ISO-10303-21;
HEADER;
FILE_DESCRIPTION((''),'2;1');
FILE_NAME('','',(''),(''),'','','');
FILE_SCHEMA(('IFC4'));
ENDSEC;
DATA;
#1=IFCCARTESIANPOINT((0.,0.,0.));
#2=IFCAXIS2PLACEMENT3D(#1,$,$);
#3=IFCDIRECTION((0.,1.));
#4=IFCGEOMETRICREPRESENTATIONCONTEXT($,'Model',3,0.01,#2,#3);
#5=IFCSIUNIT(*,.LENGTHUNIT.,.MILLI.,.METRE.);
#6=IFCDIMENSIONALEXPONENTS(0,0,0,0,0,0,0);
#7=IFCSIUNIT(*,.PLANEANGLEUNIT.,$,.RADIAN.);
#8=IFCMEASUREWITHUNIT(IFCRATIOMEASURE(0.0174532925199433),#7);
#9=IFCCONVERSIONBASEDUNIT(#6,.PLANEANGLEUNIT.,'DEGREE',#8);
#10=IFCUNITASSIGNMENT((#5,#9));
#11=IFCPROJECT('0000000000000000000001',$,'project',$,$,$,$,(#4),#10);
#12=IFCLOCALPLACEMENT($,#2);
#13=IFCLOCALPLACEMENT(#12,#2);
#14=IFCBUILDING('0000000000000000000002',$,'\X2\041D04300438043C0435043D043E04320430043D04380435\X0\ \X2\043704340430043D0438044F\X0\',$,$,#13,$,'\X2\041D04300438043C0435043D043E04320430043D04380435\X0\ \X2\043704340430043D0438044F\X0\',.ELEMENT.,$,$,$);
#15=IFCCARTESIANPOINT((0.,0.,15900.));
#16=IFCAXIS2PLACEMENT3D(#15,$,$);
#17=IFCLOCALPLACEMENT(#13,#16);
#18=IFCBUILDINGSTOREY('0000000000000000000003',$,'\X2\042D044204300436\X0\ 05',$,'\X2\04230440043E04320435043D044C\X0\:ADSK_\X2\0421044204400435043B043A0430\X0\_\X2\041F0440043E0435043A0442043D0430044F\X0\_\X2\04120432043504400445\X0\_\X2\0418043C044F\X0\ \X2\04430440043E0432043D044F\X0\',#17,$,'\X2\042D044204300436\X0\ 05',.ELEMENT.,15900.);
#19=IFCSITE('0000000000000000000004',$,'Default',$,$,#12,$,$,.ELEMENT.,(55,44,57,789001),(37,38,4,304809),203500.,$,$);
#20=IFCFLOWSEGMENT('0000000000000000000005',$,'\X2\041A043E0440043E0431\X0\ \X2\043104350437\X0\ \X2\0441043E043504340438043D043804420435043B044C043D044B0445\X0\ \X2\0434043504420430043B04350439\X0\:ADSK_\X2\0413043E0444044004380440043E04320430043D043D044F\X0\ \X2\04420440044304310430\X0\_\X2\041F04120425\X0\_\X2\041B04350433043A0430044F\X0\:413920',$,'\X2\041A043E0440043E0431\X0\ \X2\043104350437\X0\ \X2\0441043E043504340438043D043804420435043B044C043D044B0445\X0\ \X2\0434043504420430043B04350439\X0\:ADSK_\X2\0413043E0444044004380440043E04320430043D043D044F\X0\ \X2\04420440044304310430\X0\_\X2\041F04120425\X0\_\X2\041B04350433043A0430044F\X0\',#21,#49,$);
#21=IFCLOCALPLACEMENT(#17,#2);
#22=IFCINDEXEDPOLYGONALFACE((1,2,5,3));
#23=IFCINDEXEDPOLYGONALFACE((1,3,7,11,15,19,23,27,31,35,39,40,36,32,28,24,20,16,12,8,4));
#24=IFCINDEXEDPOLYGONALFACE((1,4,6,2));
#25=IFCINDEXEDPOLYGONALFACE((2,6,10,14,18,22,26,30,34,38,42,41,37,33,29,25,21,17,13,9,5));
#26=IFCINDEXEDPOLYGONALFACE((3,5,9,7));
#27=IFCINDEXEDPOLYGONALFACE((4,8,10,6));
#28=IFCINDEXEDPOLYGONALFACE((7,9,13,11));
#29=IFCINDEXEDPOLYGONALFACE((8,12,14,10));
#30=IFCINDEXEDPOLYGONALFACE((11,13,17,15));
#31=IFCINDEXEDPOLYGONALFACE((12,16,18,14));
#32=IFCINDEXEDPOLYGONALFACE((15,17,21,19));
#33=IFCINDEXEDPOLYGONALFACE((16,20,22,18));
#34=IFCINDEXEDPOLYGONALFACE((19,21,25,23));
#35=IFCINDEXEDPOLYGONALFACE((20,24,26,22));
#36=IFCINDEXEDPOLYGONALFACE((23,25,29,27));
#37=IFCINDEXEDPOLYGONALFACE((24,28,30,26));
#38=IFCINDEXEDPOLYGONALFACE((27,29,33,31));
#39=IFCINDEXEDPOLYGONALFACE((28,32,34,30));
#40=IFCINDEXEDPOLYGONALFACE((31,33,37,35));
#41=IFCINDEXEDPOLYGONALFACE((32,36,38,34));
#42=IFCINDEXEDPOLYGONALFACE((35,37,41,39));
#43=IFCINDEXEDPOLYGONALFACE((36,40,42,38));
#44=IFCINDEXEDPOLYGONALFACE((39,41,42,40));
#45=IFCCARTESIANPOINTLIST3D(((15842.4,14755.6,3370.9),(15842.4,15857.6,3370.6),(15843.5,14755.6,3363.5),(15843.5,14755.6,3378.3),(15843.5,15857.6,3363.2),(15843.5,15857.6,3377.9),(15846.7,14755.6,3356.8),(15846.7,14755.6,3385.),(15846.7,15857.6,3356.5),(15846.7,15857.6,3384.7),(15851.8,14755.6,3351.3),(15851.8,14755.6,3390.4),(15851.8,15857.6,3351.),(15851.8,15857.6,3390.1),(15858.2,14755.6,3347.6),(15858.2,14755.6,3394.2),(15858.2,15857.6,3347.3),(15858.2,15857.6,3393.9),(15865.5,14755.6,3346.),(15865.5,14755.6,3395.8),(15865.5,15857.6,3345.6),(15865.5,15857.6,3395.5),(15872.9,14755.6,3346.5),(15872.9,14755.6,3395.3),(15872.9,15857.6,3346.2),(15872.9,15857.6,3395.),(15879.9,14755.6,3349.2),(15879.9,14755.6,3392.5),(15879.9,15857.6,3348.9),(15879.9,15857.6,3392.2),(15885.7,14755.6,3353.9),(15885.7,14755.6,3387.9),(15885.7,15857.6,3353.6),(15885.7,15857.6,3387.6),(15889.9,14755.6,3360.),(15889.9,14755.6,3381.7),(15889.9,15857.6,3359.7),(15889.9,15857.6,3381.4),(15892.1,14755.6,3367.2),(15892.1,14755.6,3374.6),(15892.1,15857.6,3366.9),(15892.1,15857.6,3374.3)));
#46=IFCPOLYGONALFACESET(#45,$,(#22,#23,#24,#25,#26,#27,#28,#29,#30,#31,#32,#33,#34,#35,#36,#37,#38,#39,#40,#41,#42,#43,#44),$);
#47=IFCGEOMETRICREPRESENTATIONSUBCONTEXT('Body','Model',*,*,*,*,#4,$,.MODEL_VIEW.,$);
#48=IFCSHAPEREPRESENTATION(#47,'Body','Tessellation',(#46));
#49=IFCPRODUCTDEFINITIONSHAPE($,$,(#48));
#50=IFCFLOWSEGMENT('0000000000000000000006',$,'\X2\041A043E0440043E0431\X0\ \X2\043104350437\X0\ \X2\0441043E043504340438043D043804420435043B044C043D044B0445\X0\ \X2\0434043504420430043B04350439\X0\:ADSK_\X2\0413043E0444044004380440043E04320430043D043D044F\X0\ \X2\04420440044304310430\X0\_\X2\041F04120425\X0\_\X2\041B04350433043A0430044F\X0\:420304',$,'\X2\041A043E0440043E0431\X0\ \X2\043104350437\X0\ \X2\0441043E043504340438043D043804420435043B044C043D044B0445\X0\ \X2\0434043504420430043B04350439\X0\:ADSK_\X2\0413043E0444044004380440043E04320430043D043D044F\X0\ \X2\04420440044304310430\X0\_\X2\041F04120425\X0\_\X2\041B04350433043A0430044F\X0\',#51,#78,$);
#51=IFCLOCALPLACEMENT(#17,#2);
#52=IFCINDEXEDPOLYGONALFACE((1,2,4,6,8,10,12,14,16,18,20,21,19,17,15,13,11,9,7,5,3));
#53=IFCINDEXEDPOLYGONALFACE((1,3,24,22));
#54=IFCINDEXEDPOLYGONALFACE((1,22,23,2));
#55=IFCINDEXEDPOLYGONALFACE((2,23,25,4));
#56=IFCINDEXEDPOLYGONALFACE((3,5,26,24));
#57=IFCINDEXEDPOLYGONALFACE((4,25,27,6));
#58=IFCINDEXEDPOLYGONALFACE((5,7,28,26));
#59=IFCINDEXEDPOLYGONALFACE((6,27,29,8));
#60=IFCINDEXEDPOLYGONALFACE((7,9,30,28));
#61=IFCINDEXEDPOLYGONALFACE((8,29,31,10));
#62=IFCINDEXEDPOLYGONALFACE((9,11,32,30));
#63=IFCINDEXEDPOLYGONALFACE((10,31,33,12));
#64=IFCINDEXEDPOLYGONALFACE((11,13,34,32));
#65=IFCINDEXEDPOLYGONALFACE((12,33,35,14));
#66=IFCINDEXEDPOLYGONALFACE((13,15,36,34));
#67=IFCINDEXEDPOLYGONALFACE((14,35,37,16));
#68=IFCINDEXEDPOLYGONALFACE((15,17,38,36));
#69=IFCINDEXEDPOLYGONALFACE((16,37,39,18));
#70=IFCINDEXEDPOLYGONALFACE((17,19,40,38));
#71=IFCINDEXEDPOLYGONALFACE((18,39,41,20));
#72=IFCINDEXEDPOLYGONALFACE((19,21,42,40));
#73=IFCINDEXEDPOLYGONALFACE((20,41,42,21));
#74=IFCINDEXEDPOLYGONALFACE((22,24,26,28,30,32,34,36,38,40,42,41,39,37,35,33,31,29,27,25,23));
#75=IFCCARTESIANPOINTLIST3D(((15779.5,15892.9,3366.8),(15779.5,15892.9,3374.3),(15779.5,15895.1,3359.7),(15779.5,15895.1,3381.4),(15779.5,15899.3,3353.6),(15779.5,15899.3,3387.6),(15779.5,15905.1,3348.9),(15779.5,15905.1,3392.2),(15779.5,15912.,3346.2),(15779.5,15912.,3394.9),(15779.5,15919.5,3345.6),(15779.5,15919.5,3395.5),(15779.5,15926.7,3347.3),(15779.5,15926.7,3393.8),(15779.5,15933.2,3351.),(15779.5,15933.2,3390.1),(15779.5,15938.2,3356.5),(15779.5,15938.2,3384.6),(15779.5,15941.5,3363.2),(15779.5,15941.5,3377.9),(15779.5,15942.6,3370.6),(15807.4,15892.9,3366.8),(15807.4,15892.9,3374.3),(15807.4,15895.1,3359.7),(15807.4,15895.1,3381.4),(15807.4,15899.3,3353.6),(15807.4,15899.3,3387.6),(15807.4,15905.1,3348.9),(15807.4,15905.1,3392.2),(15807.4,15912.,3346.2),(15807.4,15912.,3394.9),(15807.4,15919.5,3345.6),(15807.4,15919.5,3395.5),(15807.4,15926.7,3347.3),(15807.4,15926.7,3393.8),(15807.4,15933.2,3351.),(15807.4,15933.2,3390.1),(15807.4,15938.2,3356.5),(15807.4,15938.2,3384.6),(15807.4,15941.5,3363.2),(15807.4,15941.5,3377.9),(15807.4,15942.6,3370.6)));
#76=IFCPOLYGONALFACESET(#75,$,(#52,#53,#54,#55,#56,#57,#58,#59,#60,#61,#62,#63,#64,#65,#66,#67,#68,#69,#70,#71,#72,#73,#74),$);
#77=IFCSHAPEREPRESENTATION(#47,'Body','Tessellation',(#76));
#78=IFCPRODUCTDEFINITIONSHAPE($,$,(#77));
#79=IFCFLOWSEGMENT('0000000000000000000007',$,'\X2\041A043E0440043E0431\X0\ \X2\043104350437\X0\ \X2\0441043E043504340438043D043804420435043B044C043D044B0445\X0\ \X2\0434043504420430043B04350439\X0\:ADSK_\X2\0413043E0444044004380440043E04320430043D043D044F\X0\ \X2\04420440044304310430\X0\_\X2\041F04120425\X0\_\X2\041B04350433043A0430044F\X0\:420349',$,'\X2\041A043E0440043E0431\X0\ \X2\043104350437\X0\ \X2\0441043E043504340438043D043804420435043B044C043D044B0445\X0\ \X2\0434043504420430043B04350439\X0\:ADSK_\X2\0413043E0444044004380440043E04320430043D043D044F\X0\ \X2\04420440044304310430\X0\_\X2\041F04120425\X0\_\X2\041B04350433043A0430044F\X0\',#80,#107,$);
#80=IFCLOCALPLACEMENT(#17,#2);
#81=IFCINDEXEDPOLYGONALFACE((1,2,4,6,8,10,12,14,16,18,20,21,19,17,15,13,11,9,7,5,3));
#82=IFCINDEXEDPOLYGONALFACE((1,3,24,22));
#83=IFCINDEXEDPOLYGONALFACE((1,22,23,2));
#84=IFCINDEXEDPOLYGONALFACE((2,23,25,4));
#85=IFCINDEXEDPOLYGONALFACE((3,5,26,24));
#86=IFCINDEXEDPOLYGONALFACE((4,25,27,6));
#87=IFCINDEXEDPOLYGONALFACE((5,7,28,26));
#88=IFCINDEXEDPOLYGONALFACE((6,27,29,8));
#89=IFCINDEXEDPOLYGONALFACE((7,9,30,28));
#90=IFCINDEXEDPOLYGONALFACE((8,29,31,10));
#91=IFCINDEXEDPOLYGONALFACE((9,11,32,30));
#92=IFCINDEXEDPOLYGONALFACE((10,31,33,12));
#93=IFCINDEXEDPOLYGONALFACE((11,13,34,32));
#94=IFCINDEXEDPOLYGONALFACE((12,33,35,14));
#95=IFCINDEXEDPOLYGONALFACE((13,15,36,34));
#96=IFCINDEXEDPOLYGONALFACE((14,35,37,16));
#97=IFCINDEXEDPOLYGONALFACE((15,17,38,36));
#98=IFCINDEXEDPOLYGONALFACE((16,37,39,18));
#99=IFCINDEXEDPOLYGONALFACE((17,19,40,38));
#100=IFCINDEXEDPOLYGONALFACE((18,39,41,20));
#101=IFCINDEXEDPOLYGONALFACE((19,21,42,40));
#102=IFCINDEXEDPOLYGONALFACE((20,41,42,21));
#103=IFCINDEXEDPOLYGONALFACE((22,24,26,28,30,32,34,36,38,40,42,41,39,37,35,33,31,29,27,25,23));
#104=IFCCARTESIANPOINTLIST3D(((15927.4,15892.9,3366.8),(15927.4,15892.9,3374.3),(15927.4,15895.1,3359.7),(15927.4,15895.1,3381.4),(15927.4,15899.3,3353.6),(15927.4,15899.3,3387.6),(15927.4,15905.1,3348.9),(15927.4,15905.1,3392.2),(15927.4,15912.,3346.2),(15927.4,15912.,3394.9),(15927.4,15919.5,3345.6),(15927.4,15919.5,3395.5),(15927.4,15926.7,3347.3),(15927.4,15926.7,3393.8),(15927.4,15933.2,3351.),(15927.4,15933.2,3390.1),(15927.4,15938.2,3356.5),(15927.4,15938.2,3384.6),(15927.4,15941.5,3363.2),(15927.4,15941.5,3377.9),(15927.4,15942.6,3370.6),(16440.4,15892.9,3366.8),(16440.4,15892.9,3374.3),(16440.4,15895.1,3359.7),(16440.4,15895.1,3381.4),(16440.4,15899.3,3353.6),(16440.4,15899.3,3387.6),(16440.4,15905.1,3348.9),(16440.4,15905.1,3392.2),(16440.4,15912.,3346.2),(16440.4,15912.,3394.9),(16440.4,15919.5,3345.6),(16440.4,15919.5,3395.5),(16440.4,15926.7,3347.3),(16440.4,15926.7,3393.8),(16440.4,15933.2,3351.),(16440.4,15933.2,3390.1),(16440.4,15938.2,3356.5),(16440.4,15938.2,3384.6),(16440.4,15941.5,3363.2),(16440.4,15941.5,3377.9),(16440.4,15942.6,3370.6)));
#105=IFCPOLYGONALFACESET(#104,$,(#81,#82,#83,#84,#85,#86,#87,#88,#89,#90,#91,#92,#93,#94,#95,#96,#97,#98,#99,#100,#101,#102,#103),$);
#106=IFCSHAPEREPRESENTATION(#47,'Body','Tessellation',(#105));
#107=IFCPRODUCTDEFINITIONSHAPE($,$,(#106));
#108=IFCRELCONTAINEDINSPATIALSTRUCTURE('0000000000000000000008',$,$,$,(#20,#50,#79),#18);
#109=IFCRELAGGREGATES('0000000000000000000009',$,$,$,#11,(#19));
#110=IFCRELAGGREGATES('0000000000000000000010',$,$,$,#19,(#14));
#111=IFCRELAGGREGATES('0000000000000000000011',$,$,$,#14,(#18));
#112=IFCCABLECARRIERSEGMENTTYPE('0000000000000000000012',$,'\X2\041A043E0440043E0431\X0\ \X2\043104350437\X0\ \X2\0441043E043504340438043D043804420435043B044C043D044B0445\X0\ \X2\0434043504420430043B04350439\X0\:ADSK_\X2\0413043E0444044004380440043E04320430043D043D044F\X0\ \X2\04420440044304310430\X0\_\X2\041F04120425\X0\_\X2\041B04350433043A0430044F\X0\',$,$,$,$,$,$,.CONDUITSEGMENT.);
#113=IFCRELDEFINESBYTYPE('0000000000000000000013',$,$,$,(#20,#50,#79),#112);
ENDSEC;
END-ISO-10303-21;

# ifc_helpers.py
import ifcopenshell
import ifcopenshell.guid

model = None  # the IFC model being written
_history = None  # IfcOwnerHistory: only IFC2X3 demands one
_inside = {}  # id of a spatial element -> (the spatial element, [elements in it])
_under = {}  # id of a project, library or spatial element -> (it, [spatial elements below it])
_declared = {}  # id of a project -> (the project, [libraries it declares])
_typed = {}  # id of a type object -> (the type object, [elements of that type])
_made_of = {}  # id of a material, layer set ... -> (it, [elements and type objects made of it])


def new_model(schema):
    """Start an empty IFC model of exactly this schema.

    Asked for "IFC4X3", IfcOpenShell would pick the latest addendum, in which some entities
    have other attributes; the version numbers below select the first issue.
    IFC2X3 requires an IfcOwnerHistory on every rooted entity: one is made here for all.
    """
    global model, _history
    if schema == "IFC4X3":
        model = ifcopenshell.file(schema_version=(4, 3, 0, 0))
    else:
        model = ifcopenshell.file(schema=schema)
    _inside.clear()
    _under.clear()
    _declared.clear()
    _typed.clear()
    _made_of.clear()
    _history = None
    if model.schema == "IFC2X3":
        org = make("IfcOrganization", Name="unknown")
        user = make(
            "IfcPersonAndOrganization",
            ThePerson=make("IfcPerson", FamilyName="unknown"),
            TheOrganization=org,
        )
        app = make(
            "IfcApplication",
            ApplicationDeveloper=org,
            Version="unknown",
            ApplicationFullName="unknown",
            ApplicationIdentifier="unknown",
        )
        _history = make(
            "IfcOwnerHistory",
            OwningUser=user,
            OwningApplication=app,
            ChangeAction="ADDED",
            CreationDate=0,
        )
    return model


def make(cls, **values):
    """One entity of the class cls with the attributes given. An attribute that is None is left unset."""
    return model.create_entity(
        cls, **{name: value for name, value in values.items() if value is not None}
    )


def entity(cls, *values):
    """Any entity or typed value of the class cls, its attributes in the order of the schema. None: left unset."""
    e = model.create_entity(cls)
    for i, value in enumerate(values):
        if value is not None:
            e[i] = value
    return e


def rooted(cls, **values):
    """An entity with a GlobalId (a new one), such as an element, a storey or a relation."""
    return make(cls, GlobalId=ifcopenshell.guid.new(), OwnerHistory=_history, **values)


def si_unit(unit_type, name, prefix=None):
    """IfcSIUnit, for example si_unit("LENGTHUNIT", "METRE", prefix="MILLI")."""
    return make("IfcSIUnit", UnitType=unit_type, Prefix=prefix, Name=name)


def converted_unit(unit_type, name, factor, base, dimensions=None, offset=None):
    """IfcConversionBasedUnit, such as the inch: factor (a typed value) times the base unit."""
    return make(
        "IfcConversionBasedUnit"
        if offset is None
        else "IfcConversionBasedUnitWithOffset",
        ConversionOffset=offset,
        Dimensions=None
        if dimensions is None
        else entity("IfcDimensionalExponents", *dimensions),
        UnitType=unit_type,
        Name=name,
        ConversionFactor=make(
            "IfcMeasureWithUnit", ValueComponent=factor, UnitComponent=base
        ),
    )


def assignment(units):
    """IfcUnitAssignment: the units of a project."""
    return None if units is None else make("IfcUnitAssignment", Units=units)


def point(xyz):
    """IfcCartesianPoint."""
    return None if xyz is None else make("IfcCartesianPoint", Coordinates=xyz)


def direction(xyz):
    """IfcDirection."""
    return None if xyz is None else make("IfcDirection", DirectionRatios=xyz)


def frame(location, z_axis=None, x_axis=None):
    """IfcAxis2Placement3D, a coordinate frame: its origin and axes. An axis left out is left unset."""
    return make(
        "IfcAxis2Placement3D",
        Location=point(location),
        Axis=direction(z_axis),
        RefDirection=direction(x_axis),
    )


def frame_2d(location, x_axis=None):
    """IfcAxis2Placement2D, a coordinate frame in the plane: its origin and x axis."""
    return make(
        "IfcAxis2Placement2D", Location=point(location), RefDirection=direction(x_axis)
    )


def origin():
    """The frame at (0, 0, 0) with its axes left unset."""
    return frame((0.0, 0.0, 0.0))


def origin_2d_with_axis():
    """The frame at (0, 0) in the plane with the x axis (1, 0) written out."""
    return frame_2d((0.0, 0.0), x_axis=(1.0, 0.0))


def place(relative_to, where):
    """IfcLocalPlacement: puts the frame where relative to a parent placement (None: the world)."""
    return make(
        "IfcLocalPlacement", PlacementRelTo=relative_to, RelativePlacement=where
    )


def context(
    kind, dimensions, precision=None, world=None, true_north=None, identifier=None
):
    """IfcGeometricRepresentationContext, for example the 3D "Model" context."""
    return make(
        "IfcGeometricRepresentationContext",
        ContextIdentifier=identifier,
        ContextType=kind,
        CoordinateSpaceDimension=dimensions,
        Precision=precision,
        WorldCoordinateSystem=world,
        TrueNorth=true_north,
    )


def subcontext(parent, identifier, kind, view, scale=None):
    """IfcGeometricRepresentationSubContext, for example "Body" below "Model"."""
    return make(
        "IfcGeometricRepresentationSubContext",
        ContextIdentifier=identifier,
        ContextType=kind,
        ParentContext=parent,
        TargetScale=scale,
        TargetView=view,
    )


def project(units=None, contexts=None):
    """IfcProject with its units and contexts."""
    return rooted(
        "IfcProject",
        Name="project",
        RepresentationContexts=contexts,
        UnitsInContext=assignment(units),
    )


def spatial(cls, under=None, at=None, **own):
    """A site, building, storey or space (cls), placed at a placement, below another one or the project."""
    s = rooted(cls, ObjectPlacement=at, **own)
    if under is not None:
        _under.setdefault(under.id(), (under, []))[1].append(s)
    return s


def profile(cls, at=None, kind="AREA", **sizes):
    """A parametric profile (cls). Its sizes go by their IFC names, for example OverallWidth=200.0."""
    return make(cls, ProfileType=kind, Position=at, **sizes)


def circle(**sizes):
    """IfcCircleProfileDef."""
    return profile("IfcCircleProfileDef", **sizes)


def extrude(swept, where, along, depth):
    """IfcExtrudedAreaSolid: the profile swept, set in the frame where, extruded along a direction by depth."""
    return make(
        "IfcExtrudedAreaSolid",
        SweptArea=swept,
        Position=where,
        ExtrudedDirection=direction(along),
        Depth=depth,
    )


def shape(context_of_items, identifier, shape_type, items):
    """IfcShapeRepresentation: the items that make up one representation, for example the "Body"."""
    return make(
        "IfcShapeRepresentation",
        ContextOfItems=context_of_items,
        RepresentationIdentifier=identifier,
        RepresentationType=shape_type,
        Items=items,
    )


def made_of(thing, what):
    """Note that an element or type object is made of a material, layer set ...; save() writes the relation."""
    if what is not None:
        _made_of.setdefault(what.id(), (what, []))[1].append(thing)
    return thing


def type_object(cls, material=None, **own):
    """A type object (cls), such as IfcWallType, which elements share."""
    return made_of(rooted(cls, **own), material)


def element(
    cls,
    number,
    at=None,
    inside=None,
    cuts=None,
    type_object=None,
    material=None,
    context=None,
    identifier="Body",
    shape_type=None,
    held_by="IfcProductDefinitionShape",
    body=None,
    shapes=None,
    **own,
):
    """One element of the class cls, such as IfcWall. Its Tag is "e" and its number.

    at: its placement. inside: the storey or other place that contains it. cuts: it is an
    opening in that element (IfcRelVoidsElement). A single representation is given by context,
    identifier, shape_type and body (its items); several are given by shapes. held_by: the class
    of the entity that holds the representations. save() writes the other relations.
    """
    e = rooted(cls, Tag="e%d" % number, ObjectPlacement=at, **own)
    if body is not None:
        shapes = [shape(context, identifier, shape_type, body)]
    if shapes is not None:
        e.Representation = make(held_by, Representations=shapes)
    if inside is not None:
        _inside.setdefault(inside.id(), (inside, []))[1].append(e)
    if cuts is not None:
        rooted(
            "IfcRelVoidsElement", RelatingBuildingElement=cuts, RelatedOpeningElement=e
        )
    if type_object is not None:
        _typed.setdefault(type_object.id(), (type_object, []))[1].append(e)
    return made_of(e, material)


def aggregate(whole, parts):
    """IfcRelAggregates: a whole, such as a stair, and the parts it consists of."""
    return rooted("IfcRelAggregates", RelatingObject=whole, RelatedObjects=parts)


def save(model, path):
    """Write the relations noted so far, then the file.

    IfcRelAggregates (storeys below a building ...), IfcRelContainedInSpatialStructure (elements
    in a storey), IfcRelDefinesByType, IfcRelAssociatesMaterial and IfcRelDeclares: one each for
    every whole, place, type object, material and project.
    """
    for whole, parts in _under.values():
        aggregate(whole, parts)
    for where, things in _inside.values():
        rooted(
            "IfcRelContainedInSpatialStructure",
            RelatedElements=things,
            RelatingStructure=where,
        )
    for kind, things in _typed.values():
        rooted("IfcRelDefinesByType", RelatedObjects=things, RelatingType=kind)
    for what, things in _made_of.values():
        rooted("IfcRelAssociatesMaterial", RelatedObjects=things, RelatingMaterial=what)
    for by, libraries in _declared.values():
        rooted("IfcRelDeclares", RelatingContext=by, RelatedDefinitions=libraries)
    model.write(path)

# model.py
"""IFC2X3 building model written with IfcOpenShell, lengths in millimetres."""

from ifc_helpers import new_model, entity, si_unit, converted_unit, direction, frame, frame_2d, origin, origin_2d_with_axis, place, context, subcontext, project, spatial, circle, extrude, type_object, element, save


model = new_model("IFC2X3")

# Units and contexts
model_context = context("Model", 3, precision=0.01, world=origin(), true_north=direction((0.0, 1.0)))
body_context = subcontext(model_context, "Body", "Model", "MODEL_VIEW")
ifc_project = project(units=[si_unit("LENGTHUNIT", "METRE", prefix="MILLI"), converted_unit("PLANEANGLEUNIT", "DEGREE", entity("IfcRatioMeasure", 0.0174532925199433), si_unit("PLANEANGLEUNIT", "RADIAN"), dimensions=[0, 0, 0, 0, 0, 0, 0])], contexts=[model_context])

# Site, building, storey
site_placement = place(None, frame((0.0, 0.0, 0.0)))
site = spatial("IfcSite", under=ifc_project, at=site_placement, Name="Default", CompositionType="ELEMENT", RefLatitude=(55, 44, 57, 789001), RefLongitude=(37, 38, 4, 304809), RefElevation=203500.0)
building_placement = place(site_placement, origin())
building = spatial("IfcBuilding", under=site, at=building_placement, Name="Наименование здания", LongName="Наименование здания", CompositionType="ELEMENT")
storey_placement = place(building_placement, frame((0.0, 0.0, 15900.0)))
storey = spatial("IfcBuildingStorey", under=building, at=storey_placement, Name="Этаж 05", ObjectType="Уровень:ADSK_Стрелка_Проектная_Вверх_Имя уровня", LongName="Этаж 05", CompositionType="ELEMENT", Elevation=15900.0)

# Flow segments
cable_carrier_segment_type = type_object("IfcCableCarrierSegmentType", Name="Короб без соединительных деталей:ADSK_Гофрировання труба_ПВХ_Легкая", PredefinedType="CONDUITSEGMENT")
flow_segment_1_placement = place(storey_placement, frame((15840.8, 14755.6, 3344.0)))
element("IfcFlowSegment", 1, at=flow_segment_1_placement, inside=storey, type_object=cable_carrier_segment_type, Name="Короб без соединительных деталей:ADSK_Гофрировання труба_ПВХ_Легкая:413920", ObjectType="Короб без соединительных деталей:ADSK_Гофрировання труба_ПВХ_Легкая", context=body_context, shape_type="SweptSolid", body=[
    extrude(circle(Radius=25.0, at=origin_2d_with_axis()), frame((26.6, 1102.0, 26.6), z_axis=(0.000002, -1.0, 0.000285), x_axis=(-1.0, -0.000002, 0.0)), (0.0, 0.0, 1.0), 1102.0),
])
flow_segment_2_placement = place(storey_placement, frame((15779.5, 15891.0, 3344.0)))
element("IfcFlowSegment", 2, at=flow_segment_2_placement, inside=storey, type_object=cable_carrier_segment_type, Name="Короб без соединительных деталей:ADSK_Гофрировання труба_ПВХ_Легкая:420304", ObjectType="Короб без соединительных деталей:ADSK_Гофрировання труба_ПВХ_Легкая", context=body_context, shape_type="SweptSolid", body=[
    extrude(circle(Radius=25.0, at=frame_2d((0.0, 0.0), x_axis=(1.0, 0.0))), frame((0.0, 26.6, 26.6), z_axis=(1.0, -0.000002, 0.0), x_axis=(0.000002, 1.0, 0.0)), (0.0, 0.0, 1.0), 27.9),
])
flow_segment_3_placement = place(storey_placement, frame((15927.4, 15891.0, 3344.0)))
element("IfcFlowSegment", 3, at=flow_segment_3_placement, inside=storey, type_object=cable_carrier_segment_type, Name="Короб без соединительных деталей:ADSK_Гофрировання труба_ПВХ_Легкая:420349", ObjectType="Короб без соединительных деталей:ADSK_Гофрировання труба_ПВХ_Легкая", context=body_context, shape_type="SweptSolid", body=[
    extrude(circle(Radius=25.0, at=frame_2d((0.0, 0.0), x_axis=(1.0, 0.0))), frame((0.0, 26.6, 26.6), z_axis=(1.0, -0.000002, 0.0), x_axis=(0.000002, 1.0, 0.0)), (0.0, 0.0, 1.0), 513.0),
])

save(model, "model.ifc")
